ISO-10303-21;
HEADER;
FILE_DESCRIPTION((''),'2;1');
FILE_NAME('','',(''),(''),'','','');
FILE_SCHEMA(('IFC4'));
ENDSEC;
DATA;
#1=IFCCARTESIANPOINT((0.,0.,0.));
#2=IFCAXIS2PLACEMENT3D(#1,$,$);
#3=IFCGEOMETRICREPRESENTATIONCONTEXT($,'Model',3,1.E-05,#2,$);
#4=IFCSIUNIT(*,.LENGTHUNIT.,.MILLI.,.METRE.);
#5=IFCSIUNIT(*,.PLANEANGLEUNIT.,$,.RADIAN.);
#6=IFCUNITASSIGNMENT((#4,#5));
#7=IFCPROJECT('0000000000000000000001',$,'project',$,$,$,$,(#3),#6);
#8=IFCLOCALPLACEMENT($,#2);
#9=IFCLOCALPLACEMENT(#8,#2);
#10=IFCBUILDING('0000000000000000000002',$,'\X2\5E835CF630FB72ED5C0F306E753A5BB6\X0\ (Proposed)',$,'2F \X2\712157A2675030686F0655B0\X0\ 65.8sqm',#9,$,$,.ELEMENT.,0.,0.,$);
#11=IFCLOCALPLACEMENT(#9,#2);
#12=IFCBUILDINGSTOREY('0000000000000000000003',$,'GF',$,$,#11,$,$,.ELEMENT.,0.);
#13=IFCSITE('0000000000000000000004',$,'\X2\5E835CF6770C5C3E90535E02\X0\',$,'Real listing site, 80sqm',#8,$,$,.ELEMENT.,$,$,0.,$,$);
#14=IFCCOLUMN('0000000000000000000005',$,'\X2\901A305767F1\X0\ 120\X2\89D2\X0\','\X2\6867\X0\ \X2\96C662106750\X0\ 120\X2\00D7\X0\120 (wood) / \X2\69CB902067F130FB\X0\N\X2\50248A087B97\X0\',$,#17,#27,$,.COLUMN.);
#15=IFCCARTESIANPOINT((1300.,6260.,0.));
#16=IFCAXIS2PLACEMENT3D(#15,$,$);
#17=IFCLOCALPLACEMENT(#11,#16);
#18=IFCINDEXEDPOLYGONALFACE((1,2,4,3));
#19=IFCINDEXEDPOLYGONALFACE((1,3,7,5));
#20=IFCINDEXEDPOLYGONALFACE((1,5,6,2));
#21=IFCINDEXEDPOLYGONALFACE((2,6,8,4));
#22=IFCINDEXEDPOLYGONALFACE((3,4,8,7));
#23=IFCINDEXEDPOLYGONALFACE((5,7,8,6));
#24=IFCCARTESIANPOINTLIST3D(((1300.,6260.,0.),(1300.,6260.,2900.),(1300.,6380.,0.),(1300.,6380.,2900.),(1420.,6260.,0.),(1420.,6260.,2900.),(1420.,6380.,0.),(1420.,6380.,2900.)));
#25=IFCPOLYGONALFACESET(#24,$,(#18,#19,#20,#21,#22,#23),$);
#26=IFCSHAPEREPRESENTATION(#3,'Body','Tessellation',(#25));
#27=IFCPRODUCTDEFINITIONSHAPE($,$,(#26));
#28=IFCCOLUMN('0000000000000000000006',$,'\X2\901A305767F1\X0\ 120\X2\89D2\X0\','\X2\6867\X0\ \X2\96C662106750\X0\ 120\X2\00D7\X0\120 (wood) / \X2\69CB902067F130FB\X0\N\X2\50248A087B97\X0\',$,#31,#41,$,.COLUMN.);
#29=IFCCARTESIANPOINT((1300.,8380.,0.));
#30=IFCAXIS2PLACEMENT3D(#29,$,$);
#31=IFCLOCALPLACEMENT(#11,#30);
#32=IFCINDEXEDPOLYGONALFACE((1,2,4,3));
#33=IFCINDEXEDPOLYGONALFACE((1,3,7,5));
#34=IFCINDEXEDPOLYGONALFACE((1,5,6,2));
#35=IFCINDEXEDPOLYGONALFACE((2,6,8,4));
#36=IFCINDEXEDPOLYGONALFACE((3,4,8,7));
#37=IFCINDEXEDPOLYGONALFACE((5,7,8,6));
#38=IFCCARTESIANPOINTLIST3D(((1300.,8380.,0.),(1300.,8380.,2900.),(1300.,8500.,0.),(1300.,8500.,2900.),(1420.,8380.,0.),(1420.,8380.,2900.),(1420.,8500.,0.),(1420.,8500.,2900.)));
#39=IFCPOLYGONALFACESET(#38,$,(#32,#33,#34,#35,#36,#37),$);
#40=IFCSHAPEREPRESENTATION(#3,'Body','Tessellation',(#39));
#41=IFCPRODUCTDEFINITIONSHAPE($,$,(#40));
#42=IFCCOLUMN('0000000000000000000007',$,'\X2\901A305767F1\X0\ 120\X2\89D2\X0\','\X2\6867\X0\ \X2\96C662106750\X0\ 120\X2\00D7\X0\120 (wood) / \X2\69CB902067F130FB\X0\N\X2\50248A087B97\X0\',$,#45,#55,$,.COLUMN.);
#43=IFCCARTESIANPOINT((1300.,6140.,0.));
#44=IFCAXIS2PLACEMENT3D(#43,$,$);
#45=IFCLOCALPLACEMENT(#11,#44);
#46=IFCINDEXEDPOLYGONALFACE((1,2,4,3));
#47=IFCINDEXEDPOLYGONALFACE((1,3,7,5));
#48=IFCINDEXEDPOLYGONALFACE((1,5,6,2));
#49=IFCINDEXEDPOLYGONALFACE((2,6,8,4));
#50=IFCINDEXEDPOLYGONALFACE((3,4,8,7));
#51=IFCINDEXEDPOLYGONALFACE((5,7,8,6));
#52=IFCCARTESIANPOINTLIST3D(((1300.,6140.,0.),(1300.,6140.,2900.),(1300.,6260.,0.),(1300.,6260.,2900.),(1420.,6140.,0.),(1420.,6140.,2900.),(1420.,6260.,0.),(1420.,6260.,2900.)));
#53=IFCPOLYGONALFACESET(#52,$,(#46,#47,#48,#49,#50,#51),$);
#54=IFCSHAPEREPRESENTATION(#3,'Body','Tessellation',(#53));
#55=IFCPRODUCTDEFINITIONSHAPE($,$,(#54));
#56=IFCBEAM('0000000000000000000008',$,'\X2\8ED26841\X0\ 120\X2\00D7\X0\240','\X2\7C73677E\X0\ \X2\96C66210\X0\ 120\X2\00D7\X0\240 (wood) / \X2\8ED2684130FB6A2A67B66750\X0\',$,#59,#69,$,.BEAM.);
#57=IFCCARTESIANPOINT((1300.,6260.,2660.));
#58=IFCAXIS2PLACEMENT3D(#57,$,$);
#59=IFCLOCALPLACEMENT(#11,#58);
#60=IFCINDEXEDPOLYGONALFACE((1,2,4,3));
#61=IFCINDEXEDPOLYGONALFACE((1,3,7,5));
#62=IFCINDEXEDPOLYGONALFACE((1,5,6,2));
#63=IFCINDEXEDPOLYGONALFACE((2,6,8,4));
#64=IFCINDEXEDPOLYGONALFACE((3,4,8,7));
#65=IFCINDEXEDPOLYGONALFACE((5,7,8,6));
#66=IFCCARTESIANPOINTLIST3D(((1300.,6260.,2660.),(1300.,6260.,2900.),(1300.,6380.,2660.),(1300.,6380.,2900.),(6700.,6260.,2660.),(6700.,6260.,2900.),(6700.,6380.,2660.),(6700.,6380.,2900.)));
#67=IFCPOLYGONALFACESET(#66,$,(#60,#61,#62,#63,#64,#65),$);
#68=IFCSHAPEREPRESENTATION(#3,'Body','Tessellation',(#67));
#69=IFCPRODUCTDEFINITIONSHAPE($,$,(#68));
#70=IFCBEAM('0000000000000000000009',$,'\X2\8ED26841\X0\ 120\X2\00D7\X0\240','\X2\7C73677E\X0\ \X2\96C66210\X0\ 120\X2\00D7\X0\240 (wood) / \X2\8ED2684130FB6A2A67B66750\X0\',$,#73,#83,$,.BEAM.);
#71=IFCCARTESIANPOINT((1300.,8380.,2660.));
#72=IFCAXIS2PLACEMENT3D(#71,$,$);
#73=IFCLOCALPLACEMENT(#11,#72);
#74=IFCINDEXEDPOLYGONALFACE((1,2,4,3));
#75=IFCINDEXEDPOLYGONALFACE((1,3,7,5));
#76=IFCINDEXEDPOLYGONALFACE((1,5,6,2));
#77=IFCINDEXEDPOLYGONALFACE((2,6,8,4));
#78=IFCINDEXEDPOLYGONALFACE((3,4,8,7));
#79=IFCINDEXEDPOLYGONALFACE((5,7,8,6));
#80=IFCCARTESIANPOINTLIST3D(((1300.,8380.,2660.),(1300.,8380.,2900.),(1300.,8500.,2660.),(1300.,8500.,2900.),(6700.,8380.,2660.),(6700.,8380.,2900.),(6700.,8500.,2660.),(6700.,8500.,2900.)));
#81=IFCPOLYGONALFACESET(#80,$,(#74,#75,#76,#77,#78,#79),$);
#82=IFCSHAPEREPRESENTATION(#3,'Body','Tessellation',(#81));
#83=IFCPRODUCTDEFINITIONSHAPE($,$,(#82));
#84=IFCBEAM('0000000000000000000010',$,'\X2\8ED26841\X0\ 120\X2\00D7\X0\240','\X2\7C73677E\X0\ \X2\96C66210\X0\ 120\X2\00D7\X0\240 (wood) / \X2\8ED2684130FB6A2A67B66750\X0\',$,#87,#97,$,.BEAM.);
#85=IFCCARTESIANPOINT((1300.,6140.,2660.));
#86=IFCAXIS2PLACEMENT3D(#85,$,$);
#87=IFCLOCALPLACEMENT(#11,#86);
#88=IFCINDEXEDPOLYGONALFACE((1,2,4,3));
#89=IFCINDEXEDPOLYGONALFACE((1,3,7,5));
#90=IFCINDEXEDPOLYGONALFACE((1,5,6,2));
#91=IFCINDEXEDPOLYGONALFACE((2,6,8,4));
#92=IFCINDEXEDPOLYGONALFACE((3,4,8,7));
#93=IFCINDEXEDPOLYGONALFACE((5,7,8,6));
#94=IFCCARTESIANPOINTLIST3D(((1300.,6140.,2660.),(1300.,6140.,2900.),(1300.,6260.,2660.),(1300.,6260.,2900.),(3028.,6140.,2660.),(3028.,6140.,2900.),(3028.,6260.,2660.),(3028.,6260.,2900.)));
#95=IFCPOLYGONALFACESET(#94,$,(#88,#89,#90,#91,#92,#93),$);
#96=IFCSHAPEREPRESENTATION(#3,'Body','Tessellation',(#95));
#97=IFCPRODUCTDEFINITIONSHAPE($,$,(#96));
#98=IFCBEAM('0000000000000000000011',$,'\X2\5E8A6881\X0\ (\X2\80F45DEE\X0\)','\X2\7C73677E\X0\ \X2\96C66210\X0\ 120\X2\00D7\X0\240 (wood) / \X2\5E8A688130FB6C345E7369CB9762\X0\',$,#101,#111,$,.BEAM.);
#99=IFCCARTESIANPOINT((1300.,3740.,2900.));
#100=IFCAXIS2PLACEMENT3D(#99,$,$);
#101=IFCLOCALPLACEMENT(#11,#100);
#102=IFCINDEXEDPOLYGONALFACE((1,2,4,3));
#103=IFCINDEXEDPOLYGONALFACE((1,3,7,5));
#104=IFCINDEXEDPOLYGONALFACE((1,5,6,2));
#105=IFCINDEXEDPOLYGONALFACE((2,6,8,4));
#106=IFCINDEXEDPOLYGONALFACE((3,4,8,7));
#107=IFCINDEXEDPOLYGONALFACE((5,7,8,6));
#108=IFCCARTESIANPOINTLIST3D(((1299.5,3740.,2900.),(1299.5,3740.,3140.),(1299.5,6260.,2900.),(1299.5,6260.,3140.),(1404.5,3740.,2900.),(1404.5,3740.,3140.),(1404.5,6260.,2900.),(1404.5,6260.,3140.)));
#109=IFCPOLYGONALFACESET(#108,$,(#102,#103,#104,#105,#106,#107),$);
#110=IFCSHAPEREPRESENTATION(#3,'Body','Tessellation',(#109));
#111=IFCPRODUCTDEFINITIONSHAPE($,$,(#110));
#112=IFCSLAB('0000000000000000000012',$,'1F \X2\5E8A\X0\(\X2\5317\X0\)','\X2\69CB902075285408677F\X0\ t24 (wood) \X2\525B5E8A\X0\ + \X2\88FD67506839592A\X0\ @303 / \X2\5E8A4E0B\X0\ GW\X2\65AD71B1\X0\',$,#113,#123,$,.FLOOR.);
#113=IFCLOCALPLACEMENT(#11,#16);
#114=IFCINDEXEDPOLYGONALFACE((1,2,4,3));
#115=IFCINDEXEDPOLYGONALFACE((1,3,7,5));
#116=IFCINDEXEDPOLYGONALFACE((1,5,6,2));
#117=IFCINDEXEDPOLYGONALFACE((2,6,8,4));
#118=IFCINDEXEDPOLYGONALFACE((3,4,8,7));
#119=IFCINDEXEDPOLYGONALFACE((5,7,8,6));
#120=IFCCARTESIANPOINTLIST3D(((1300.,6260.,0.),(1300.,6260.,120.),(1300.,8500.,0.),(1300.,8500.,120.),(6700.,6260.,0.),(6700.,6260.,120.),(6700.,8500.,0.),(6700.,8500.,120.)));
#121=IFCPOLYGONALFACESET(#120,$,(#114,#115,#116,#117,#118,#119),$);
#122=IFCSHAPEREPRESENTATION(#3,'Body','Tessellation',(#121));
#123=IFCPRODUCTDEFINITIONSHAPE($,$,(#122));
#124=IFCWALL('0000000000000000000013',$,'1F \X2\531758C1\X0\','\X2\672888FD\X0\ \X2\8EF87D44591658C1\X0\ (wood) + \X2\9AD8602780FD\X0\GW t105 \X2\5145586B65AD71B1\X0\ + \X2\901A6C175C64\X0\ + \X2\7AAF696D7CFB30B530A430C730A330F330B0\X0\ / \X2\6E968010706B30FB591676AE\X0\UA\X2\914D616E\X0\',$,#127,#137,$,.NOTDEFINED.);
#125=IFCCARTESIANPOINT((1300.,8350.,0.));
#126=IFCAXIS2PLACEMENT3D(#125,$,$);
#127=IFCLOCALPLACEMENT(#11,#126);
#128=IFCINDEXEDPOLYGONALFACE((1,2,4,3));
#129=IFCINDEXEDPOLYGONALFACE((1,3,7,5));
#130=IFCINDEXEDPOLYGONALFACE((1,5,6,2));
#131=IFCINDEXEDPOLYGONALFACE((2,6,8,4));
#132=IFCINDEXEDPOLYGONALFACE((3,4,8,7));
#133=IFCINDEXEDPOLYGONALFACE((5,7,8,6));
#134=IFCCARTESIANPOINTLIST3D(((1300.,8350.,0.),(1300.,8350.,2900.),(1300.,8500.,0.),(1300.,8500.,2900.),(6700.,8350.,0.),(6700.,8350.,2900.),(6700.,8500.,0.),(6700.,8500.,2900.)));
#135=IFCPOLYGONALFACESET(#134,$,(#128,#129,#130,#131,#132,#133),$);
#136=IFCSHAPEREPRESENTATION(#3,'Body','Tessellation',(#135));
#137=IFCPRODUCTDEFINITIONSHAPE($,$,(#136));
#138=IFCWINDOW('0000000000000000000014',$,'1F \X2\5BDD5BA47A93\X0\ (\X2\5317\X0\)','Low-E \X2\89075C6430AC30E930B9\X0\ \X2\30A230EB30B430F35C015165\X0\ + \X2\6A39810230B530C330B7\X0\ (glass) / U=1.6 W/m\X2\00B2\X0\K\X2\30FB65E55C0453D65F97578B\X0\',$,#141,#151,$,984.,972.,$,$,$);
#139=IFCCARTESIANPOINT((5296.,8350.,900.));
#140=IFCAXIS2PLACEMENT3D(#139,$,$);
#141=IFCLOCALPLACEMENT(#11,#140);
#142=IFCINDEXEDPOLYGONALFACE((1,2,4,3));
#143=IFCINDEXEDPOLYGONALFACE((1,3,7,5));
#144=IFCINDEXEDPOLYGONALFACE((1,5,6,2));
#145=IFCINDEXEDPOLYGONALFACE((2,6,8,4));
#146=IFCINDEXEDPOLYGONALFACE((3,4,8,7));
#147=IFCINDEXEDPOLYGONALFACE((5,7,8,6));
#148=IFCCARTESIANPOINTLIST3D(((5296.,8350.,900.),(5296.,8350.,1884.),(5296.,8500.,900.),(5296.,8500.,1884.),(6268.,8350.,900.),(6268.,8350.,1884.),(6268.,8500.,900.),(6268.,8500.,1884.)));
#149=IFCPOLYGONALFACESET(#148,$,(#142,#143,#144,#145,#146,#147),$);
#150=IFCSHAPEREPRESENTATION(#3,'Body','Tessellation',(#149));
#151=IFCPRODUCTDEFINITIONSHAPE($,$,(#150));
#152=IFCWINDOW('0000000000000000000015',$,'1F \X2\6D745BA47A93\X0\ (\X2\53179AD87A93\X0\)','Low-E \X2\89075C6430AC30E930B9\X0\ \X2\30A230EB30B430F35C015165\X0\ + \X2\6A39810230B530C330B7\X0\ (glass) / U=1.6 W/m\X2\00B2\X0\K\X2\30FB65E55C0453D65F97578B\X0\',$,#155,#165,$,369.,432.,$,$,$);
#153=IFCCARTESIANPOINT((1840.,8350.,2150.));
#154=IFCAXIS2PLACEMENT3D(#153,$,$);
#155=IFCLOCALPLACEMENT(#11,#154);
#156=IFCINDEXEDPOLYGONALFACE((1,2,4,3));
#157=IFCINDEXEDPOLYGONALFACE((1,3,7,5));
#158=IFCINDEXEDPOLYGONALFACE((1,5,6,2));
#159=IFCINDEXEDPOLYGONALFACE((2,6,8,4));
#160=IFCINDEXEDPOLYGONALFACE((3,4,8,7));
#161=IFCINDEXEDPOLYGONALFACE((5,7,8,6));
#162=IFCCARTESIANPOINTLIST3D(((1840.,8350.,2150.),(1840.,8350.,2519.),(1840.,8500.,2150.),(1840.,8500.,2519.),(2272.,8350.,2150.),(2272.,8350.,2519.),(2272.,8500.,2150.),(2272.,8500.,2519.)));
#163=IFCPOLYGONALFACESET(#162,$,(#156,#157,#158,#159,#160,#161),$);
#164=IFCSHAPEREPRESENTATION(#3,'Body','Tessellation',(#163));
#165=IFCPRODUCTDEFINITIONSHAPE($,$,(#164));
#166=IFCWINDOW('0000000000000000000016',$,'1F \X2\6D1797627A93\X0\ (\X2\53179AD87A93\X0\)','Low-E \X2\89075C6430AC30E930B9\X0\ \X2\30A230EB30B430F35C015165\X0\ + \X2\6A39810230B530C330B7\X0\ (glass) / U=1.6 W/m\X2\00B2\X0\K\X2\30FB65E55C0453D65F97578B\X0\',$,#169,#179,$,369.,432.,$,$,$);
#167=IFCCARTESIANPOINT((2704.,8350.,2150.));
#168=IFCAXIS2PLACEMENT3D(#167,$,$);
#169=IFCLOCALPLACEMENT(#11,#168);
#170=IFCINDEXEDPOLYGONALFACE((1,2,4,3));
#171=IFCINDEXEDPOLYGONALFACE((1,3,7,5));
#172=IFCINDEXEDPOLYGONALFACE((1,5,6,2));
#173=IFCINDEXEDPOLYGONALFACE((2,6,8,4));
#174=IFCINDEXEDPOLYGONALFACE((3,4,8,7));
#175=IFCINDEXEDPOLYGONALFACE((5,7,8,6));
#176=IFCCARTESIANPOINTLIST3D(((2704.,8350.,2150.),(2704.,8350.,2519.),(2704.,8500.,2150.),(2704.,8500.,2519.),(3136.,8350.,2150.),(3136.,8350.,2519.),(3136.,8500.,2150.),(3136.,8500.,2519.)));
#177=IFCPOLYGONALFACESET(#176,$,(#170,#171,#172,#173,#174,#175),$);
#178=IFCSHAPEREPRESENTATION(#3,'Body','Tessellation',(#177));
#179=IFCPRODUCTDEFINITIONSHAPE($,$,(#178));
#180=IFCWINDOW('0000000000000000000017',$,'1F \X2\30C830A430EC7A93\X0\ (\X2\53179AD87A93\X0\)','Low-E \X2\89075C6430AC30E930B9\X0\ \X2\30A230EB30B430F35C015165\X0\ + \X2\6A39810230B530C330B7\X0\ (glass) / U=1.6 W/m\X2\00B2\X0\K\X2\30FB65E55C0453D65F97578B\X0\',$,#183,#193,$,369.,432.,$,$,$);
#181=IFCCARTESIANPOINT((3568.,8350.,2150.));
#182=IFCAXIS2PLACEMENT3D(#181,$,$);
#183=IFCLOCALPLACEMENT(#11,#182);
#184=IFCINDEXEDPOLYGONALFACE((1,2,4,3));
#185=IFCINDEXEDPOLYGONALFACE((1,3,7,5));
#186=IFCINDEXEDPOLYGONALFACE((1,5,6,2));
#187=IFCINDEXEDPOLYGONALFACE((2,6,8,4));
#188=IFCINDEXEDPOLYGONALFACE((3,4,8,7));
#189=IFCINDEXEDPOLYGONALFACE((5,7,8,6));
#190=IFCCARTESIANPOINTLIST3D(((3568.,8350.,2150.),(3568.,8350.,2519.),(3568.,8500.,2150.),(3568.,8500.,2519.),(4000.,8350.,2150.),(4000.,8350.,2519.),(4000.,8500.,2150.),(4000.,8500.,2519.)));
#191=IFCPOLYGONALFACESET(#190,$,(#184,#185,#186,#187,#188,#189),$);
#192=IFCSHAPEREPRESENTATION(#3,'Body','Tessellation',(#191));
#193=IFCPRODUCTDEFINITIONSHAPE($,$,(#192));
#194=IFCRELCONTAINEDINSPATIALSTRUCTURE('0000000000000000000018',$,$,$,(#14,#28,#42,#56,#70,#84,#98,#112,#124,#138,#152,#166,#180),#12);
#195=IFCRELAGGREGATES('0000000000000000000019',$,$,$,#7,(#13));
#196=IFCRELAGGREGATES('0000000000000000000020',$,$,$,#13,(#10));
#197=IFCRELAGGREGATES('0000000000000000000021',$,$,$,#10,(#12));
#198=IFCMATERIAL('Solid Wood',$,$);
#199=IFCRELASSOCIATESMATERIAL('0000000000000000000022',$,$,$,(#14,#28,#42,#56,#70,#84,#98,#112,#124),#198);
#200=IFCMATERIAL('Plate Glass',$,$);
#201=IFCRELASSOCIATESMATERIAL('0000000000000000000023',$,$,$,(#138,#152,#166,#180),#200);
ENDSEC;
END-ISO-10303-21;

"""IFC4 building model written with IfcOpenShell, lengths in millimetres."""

from ifc_helpers import new_model, si_unit, frame, frame_2d, origin, place, context, project, spatial, rectangle, extrude, material, element, fill, save


model = new_model("IFC4")

# Units and contexts
model_context = context("Model", 3, precision=1e-05, world=origin())
ifc_project = project(units=[si_unit("LENGTHUNIT", "METRE", prefix="MILLI"), si_unit("PLANEANGLEUNIT", "RADIAN")], contexts=[model_context])

# Site, building, storey
site_placement = place(None, origin())
site = spatial("IfcSite", under=ifc_project, at=site_placement, Name="広島県尾道市", ObjectType="Real listing site, 80sqm", CompositionType="ELEMENT", RefElevation=0.0)
building_placement = place(site_placement, origin())
building = spatial("IfcBuilding", under=site, at=building_placement, Name="広島・狭小の町家 (Proposed)", ObjectType="2F 無垢材と漆喰 65.8sqm", CompositionType="ELEMENT", ElevationOfRefHeight=0.0, ElevationOfTerrain=0.0)
storey_placement = place(building_placement, origin())
storey = spatial("IfcBuildingStorey", under=building, at=storey_placement, Name="GF", CompositionType="ELEMENT", Elevation=0.0)

# Columns
ifc_material_1 = material(Name="Solid Wood")
column_1_placement = place(storey_placement, frame((1300.0, 6260.0, 0.0)))
element("IfcColumn", 1, at=column_1_placement, inside=storey, material=ifc_material_1, Name="通し柱 120角", Description="桧 集成材 120×120 (wood) / 構造柱・N値計算", PredefinedType="COLUMN", context=model_context, shape_type="SweptSolid", body=[
    extrude(rectangle(XDim=120.0, YDim=120.0, at=frame_2d((60.0, 60.0))), frame((1300.0, 6260.0, 0.0)), (0.0, 0.0, 1.0), 2900.0),
])
column_2_placement = place(storey_placement, frame((1300.0, 8380.0, 0.0)))
element("IfcColumn", 2, at=column_2_placement, inside=storey, material=ifc_material_1, Name="通し柱 120角", Description="桧 集成材 120×120 (wood) / 構造柱・N値計算", PredefinedType="COLUMN", context=model_context, shape_type="SweptSolid", body=[
    extrude(rectangle(XDim=120.0, YDim=120.0, at=frame_2d((60.0, 60.0))), frame((1300.0, 8380.0, 0.0)), (0.0, 0.0, 1.0), 2900.0),
])
column_3_placement = place(storey_placement, frame((1300.0, 6140.0, 0.0)))
element("IfcColumn", 3, at=column_3_placement, inside=storey, material=ifc_material_1, Name="通し柱 120角", Description="桧 集成材 120×120 (wood) / 構造柱・N値計算", PredefinedType="COLUMN", context=model_context, shape_type="SweptSolid", body=[
    extrude(rectangle(XDim=120.0, YDim=120.0, at=frame_2d((60.0, 60.0))), frame((1300.0, 6140.0, 0.0)), (0.0, 0.0, 1.0), 2900.0),
])

# Beams
beam_1_placement = place(storey_placement, frame((1300.0, 6260.0, 2660.0)))
element("IfcBeam", 4, at=beam_1_placement, inside=storey, material=ifc_material_1, Name="軒桁 120×240", Description="米松 集成 120×240 (wood) / 軒桁・横架材", PredefinedType="BEAM", context=model_context, shape_type="SweptSolid", body=[
    extrude(rectangle(XDim=5400.0, YDim=120.0, at=frame_2d((2700.0, 60.0))), frame((1300.0, 6260.0, 2660.0)), (0.0, 0.0, 1.0), 240.0),
])
beam_2_placement = place(storey_placement, frame((1300.0, 8380.0, 2660.0)))
element("IfcBeam", 5, at=beam_2_placement, inside=storey, material=ifc_material_1, Name="軒桁 120×240", Description="米松 集成 120×240 (wood) / 軒桁・横架材", PredefinedType="BEAM", context=model_context, shape_type="SweptSolid", body=[
    extrude(rectangle(XDim=5400.0, YDim=120.0, at=frame_2d((2700.0, 60.0))), frame((1300.0, 8380.0, 2660.0)), (0.0, 0.0, 1.0), 240.0),
])
beam_3_placement = place(storey_placement, frame((1300.0, 6140.0, 2660.0)))
element("IfcBeam", 6, at=beam_3_placement, inside=storey, material=ifc_material_1, Name="軒桁 120×240", Description="米松 集成 120×240 (wood) / 軒桁・横架材", PredefinedType="BEAM", context=model_context, shape_type="SweptSolid", body=[
    extrude(rectangle(XDim=1728.0, YDim=120.0, at=frame_2d((864.0, 60.0))), frame((1300.0, 6140.0, 2660.0)), (0.0, 0.0, 1.0), 240.0),
])
beam_4_placement = place(storey_placement, frame((1300.0, 3740.0, 2900.0)))
element("IfcBeam", 7, at=beam_4_placement, inside=storey, material=ifc_material_1, Name="床梁 (胴差)", Description="米松 集成 120×240 (wood) / 床梁・水平構面", PredefinedType="BEAM", context=model_context, shape_type="SweptSolid", body=[
    extrude(rectangle(XDim=105.0, YDim=2520.0, at=frame_2d((52.0, 1260.0))), frame((1300.0, 3740.0, 2900.0)), (0.0, 0.0, 1.0), 240.0),
])

# Slab
slab_placement = place(storey_placement, frame((1300.0, 6260.0, 0.0)))
element("IfcSlab", 8, at=slab_placement, inside=storey, material=ifc_material_1, Name="1F 床(北)", Description="構造用合板 t24 (wood) 剛床 + 製材根太 @303 / 床下 GW断熱", PredefinedType="FLOOR", context=model_context, shape_type="SweptSolid", body=[
    extrude(rectangle(XDim=5400.0, YDim=2240.0, at=frame_2d((2700.0, 1120.0))), frame((1300.0, 6260.0, 0.0)), (0.0, 0.0, 1.0), 120.0),
])

# Wall, openings, windows
wall_1_placement = place(storey_placement, frame((1300.0, 8350.0, 0.0)))
wall_1 = element("IfcWall", 9, at=wall_1_placement, inside=storey, material=ifc_material_1, Name="1F 北壁", Description="木製 軸組外壁 (wood) + 高性能GW t105 充填断熱 + 通気層 + 窯業系サイディング / 準耐火・外皮UA配慮", PredefinedType="NOTDEFINED", context=model_context, shape_type="SweptSolid", body=[
    extrude(rectangle(XDim=5400.0, YDim=150.0, at=frame_2d((2700.0, 75.0))), frame((1300.0, 8350.0, 0.0)), (0.0, 0.0, 1.0), 2900.0),
])
opening_1_placement = place(storey_placement, frame((5296.0, 8350.0, 900.0)))
opening_1 = element("IfcOpeningElement", 10, at=opening_1_placement, cuts=wall_1, PredefinedType="NOTDEFINED", context=model_context, shape_type="SweptSolid", body=[
    extrude(rectangle(XDim=972.0, YDim=150.0, at=frame_2d((486.0, 75.0))), frame((5296.0, 8350.0, 900.0)), (0.0, 0.0, 1.0), 984.0),
])
opening_2_placement = place(storey_placement, frame((1840.0, 8350.0, 2150.0)))
opening_2 = element("IfcOpeningElement", 11, at=opening_2_placement, cuts=wall_1, PredefinedType="NOTDEFINED", context=model_context, shape_type="SweptSolid", body=[
    extrude(rectangle(XDim=432.0, YDim=150.0, at=frame_2d((216.0, 75.0))), frame((1840.0, 8350.0, 2150.0)), (0.0, 0.0, 1.0), 369.0),
])
opening_3_placement = place(storey_placement, frame((2704.0, 8350.0, 2150.0)))
opening_3 = element("IfcOpeningElement", 12, at=opening_3_placement, cuts=wall_1, PredefinedType="NOTDEFINED", context=model_context, shape_type="SweptSolid", body=[
    extrude(rectangle(XDim=432.0, YDim=150.0, at=frame_2d((216.0, 75.0))), frame((2704.0, 8350.0, 2150.0)), (0.0, 0.0, 1.0), 369.0),
])
opening_4_placement = place(storey_placement, frame((3568.0, 8350.0, 2150.0)))
opening_4 = element("IfcOpeningElement", 13, at=opening_4_placement, cuts=wall_1, PredefinedType="NOTDEFINED", context=model_context, shape_type="SweptSolid", body=[
    extrude(rectangle(XDim=432.0, YDim=150.0, at=frame_2d((216.0, 75.0))), frame((3568.0, 8350.0, 2150.0)), (0.0, 0.0, 1.0), 369.0),
])
ifc_material_2 = material(Name="Plate Glass")
window_1_placement = place(storey_placement, frame((5296.0, 8350.0, 900.0)))
window_1 = element("IfcWindow", 14, at=window_1_placement, inside=storey, material=ifc_material_2, Name="1F 寝室窓 (北)", Description="Low-E 複層ガラス アルゴン封入 + 樹脂サッシ (glass) / U=1.6 W/m²K・日射取得型", OverallHeight=984.0, OverallWidth=972.0, context=model_context, shape_type="SweptSolid", body=[
    extrude(rectangle(XDim=972.0, YDim=150.0, at=frame_2d((486.0, 75.0))), frame((5296.0, 8350.0, 900.0)), (0.0, 0.0, 1.0), 984.0),
])
fill(opening_1, window_1)
window_2_placement = place(storey_placement, frame((1840.0, 8350.0, 2150.0)))
window_2 = element("IfcWindow", 15, at=window_2_placement, inside=storey, material=ifc_material_2, Name="1F 浴室窓 (北高窓)", Description="Low-E 複層ガラス アルゴン封入 + 樹脂サッシ (glass) / U=1.6 W/m²K・日射取得型", OverallHeight=369.0, OverallWidth=432.0, context=model_context, shape_type="SweptSolid", body=[
    extrude(rectangle(XDim=432.0, YDim=150.0, at=frame_2d((216.0, 75.0))), frame((1840.0, 8350.0, 2150.0)), (0.0, 0.0, 1.0), 369.0),
])
fill(opening_2, window_2)
window_3_placement = place(storey_placement, frame((2704.0, 8350.0, 2150.0)))
window_3 = element("IfcWindow", 16, at=window_3_placement, inside=storey, material=ifc_material_2, Name="1F 洗面窓 (北高窓)", Description="Low-E 複層ガラス アルゴン封入 + 樹脂サッシ (glass) / U=1.6 W/m²K・日射取得型", OverallHeight=369.0, OverallWidth=432.0, context=model_context, shape_type="SweptSolid", body=[
    extrude(rectangle(XDim=432.0, YDim=150.0, at=frame_2d((216.0, 75.0))), frame((2704.0, 8350.0, 2150.0)), (0.0, 0.0, 1.0), 369.0),
])
fill(opening_3, window_3)
window_4_placement = place(storey_placement, frame((3568.0, 8350.0, 2150.0)))
window_4 = element("IfcWindow", 17, at=window_4_placement, inside=storey, material=ifc_material_2, Name="1F トイレ窓 (北高窓)", Description="Low-E 複層ガラス アルゴン封入 + 樹脂サッシ (glass) / U=1.6 W/m²K・日射取得型", OverallHeight=369.0, OverallWidth=432.0, context=model_context, shape_type="SweptSolid", body=[
    extrude(rectangle(XDim=432.0, YDim=150.0, at=frame_2d((216.0, 75.0))), frame((3568.0, 8350.0, 2150.0)), (0.0, 0.0, 1.0), 369.0),
])
fill(opening_4, window_4)

save(model, "model.ifc")
